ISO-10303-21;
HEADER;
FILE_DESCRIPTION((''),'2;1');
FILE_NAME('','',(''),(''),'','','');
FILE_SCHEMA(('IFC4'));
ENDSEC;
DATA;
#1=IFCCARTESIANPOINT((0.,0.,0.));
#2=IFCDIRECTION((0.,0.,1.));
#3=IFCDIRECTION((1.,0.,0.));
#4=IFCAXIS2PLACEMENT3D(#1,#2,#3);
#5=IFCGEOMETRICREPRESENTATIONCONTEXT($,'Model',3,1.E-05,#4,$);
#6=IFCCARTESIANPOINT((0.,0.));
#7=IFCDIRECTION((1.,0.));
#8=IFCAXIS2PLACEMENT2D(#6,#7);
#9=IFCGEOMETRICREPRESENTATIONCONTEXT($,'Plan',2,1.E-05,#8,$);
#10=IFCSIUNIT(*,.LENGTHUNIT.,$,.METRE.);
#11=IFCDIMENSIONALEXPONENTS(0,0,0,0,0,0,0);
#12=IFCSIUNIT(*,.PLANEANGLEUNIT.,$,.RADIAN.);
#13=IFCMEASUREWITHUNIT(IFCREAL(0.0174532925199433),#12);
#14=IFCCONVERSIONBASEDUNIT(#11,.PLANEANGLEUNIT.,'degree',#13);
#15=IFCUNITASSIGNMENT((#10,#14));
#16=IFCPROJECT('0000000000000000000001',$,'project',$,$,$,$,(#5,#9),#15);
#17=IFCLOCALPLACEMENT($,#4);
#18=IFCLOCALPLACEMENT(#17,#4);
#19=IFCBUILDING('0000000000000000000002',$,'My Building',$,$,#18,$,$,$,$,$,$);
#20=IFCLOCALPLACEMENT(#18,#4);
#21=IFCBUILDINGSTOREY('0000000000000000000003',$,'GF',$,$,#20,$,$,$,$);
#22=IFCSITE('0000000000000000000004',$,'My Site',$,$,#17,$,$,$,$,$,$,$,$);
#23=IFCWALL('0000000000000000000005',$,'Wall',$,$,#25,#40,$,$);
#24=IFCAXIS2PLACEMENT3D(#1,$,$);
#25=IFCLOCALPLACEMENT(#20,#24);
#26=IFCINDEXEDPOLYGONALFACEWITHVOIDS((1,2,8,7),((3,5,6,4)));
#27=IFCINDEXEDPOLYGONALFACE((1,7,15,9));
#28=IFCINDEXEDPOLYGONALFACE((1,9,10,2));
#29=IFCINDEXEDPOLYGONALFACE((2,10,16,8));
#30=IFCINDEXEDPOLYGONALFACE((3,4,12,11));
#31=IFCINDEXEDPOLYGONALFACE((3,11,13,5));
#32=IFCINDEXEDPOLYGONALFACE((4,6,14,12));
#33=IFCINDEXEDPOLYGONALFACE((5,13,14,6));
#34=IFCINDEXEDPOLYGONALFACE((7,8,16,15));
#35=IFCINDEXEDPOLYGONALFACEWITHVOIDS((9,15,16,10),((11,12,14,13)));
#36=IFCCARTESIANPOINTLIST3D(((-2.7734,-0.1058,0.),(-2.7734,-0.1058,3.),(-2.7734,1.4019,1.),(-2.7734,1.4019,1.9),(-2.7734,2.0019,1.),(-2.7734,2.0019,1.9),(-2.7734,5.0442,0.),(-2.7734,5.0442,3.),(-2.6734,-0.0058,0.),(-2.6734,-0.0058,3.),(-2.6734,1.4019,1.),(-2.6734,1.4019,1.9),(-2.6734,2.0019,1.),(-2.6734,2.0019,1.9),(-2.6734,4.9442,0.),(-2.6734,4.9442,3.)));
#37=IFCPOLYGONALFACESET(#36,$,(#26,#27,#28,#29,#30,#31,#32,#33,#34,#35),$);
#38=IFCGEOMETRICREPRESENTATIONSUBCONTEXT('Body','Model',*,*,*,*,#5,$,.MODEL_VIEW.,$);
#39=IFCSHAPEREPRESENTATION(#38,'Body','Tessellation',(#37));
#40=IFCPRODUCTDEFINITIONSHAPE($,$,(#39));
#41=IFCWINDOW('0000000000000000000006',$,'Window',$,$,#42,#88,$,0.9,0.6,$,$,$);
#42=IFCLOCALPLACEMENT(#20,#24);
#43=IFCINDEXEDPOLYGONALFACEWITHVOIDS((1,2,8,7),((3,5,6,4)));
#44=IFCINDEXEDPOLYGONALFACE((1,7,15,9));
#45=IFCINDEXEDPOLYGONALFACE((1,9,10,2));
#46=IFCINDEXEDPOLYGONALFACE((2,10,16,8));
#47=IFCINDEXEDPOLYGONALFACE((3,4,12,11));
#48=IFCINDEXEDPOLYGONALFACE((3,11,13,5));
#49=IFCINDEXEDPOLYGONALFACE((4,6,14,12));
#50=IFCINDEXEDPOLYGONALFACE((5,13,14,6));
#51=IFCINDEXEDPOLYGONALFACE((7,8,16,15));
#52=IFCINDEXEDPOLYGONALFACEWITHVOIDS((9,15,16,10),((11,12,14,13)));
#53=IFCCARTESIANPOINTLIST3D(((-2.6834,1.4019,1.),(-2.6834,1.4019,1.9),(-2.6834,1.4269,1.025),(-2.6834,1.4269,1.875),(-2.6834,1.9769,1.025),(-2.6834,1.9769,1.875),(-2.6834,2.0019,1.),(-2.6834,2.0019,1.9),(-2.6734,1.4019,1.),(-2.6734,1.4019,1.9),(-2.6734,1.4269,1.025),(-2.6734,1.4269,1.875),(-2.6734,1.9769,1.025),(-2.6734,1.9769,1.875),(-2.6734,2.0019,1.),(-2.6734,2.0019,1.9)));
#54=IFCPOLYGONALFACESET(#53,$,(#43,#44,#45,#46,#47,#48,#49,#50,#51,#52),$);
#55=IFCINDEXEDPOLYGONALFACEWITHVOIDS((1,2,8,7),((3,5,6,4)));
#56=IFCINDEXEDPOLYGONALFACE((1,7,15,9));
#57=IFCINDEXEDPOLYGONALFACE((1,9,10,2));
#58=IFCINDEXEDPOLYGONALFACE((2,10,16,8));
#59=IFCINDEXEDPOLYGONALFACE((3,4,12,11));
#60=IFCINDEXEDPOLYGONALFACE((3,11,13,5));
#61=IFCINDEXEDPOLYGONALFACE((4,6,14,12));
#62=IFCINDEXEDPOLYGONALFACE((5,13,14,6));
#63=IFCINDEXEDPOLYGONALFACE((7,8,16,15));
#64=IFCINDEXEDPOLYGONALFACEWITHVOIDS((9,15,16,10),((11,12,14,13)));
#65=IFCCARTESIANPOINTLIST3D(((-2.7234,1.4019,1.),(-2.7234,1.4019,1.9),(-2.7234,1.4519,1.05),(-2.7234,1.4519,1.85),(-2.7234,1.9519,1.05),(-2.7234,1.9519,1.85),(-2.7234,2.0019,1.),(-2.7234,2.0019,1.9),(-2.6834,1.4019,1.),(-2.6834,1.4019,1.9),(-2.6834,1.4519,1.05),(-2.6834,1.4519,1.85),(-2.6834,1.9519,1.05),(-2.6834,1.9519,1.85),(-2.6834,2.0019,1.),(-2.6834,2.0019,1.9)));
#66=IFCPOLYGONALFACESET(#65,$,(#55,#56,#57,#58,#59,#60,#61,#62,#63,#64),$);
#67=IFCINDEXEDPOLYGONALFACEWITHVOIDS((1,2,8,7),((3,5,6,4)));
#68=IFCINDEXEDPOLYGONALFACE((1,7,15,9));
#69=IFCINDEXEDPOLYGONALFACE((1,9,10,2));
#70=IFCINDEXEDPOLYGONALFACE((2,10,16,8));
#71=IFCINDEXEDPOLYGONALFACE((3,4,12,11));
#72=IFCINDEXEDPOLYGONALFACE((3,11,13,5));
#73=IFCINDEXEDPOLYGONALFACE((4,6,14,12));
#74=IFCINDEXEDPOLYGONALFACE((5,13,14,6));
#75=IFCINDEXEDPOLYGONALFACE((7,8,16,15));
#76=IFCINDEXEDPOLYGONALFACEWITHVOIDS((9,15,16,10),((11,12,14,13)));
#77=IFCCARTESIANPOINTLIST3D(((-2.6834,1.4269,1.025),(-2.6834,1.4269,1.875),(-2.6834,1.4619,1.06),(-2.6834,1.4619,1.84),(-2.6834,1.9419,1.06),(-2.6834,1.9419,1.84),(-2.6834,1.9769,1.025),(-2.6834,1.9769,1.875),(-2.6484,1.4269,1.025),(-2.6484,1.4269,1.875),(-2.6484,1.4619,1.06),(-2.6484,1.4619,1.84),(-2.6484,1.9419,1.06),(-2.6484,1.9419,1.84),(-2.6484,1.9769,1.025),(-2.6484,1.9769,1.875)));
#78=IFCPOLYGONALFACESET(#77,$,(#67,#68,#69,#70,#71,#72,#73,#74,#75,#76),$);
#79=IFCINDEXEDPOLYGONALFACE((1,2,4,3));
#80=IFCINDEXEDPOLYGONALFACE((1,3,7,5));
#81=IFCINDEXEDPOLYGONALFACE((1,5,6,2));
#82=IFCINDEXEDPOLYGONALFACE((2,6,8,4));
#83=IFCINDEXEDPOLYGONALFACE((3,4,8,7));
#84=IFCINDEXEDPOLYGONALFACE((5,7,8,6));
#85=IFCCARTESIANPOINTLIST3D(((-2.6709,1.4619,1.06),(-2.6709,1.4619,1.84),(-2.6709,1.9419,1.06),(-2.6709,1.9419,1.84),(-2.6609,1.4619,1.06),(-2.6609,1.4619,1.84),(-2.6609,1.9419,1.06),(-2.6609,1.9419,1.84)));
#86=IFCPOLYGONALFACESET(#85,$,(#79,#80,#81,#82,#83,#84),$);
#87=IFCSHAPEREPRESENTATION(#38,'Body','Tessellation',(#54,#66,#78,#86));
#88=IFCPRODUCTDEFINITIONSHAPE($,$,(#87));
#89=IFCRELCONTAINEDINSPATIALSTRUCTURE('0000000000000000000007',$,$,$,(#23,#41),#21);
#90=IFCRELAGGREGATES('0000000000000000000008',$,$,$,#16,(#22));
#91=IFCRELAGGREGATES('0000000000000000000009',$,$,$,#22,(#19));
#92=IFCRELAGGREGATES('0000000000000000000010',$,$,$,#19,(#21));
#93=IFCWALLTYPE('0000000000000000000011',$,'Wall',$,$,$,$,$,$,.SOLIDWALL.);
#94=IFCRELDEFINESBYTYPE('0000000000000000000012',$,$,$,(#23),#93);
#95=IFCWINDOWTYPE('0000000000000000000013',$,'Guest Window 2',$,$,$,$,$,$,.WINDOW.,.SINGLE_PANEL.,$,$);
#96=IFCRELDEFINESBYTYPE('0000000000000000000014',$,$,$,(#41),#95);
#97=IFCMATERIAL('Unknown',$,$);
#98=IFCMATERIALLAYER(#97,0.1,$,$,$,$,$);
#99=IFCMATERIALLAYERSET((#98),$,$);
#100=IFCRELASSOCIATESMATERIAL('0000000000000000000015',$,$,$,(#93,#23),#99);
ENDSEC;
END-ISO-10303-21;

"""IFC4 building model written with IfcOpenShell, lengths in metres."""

from ifc_helpers import new_model, entity, si_unit, converted_unit, frame, origin_with_axes, origin_2d_with_axis, place, context, subcontext, project, spatial, line, indexed_curve, outline, extrude, shape, source, transform, mapped, material, layer, layer_set, layer_usage, type_object, type_shapes, element, fill, save


model = new_model("IFC4")

# Units and contexts
model_context = context("Model", 3, precision=1e-05, world=origin_with_axes())
plan_context = context("Plan", 2, precision=1e-05, world=origin_2d_with_axis())
body_context_1 = subcontext(model_context, "Body", "Model", "MODEL_VIEW")
body_context_2 = subcontext(plan_context, "Body", "Plan", "PLAN_VIEW")
ifc_project = project(units=[si_unit("LENGTHUNIT", "METRE"), converted_unit("PLANEANGLEUNIT", "degree", entity("IfcReal", 0.0174532925199433), si_unit("PLANEANGLEUNIT", "RADIAN"), dimensions=[0, 0, 0, 0, 0, 0, 0])], contexts=[model_context, plan_context])

# Site, building, storey
site_placement = place(None, origin_with_axes())
site = spatial("IfcSite", under=ifc_project, at=site_placement, Name="My Site")
building_placement = place(site_placement, origin_with_axes())
building = spatial("IfcBuilding", under=site, at=building_placement, Name="My Building")
storey_placement = place(building_placement, origin_with_axes())
storey = spatial("IfcBuildingStorey", under=building, at=storey_placement, Name="GF")

# Shared definitions
ifc_material = material(Name="Unknown")

# Shared definitions
ifc_layer_1 = layer(ifc_material, 0.1)
ifc_layer_set_1 = layer_set([ifc_layer_1])
wall_type = type_object("IfcWallType", Name="Wall", PredefinedType="SOLIDWALL", material=ifc_layer_set_1)

# Wall, opening, window
ifc_layer_usage_1 = layer_usage(ifc_layer_set_1, "AXIS2", "POSITIVE", 0.0)
wall_1_placement = place(storey_placement, frame((-2.7734, 5.0442, 0.0), z_axis=(0.0, 0.0, 1.0), x_axis=(0.0, -1.0, 0.0)))
wall_1 = element("IfcWall", 1, at=wall_1_placement, inside=storey, type_object=wall_type, material=ifc_layer_usage_1, Name="Wall", context=body_context_1, shape_type="SweptSolid", body=[
    extrude(outline(indexed_curve([(0.0, 0.0), (0.1, 0.1), (5.05, 0.1), (5.15, 0.0)], segments=[line(1, 2, 3, 4, 1)])), origin_with_axes(), (0.0, 0.0, 1.0), 3.0),
])
shared_shape_1 = source(origin_with_axes(), body_context_1, "Body", "SweptSolid", [
    extrude(outline(indexed_curve([(0.0, 0.0), (0.6, 0.0), (0.6, 0.9), (0.0, 0.9)], segments=[line(1, 2, 3, 4, 1)])), frame((0.0, -0.6, 0.0), z_axis=(0.0, -1.0, 0.0), x_axis=(1.0, 0.0, 0.0)), (0.0, 0.0, -1.0), 1.2),
])
opening_1_placement = place(wall_1_placement, frame((3.0423, 0.0, 1.0), z_axis=(0.0, 0.0, 1.0), x_axis=(1.0, 0.0, 0.0)))
opening_1 = element("IfcOpeningElement", 2, at=opening_1_placement, cuts=wall_1, PredefinedType="OPENING", context=body_context_1, shape_type="MappedRepresentation", body=[
    mapped(shared_shape_1, transform((0.0, 0.0, 0.0), x_axis=(1.0, 0.0, 0.0), y_axis=(0.0, 1.0, 0.0), z_axis=(0.0, 0.0, 1.0), scale=1.0)),
])
window_type_1 = type_object("IfcWindowType", Name="Guest Window 2", PartitioningType="SINGLE_PANEL", PredefinedType="WINDOW")
shared_shape_2 = source(origin_with_axes(), body_context_1, "Body", "SweptSolid", [
    extrude(outline(indexed_curve([(0.0, 0.0), (0.6, 0.0), (0.6, 0.9), (0.0, 0.9)], segments=[line(1, 2, 3, 4, 1)]), holes=[indexed_curve([(0.025, 0.025), (0.575, 0.025), (0.575, 0.875), (0.025, 0.875)], segments=[line(1, 2, 3, 4, 1)])]), frame((0.0, 0.09, 0.0), z_axis=(0.0, -1.0, 0.0), x_axis=(1.0, 0.0, 0.0)), (0.0, 0.0, -1.0), 0.01),
    extrude(outline(indexed_curve([(0.0, 0.0), (0.6, 0.0), (0.6, 0.9), (0.0, 0.9)], segments=[line(1, 2, 3, 4, 1)]), holes=[indexed_curve([(0.05, 0.05), (0.55, 0.05), (0.55, 0.85), (0.05, 0.85)], segments=[line(1, 2, 3, 4, 1)])]), frame((0.0, 0.05, 0.0), z_axis=(0.0, -1.0, 0.0), x_axis=(1.0, 0.0, 0.0)), (0.0, 0.0, -1.0), 0.04),
    extrude(outline(indexed_curve([(0.0, 0.0), (0.55, 0.0), (0.55, 0.85), (0.0, 0.85)], segments=[line(1, 2, 3, 4, 1)]), holes=[indexed_curve([(0.035, 0.035), (0.515, 0.035), (0.515, 0.815), (0.035, 0.815)], segments=[line(1, 2, 3, 4, 1)])]), frame((0.025, 0.09, 0.025), z_axis=(0.0, -1.0, 0.0), x_axis=(1.0, 0.0, 0.0)), (0.0, 0.0, -1.0), 0.035),
    extrude(outline(indexed_curve([(0.035, 0.035), (0.515, 0.035), (0.515, 0.815), (0.035, 0.815)], segments=[line(1, 2, 3, 4, 1)])), frame((0.025, 0.1025, 0.025), z_axis=(0.0, -1.0, 0.0), x_axis=(1.0, 0.0, 0.0)), (0.0, 0.0, -1.0), 0.01),
])
shared_shape_3 = source(origin_with_axes(), body_context_2, "Body", "Curve2D", [
    entity("IfcIndexedPolyCurve", entity("IfcCartesianPointList2D", [[0.05, 0.05], [0.55, 0.05]])),
    entity("IfcIndexedPolyCurve", entity("IfcCartesianPointList2D", [[0.0, 0.1], [0.025, 0.1], [0.025, 0.09], [0.05, 0.09], [0.05, 0.05], [0.0, 0.05]]), [entity("IfcLineIndex", [1, 2, 3, 4, 5, 6, 1])]),
    entity("IfcIndexedPolyCurve", entity("IfcCartesianPointList2D", [[0.6, 0.1], [0.575, 0.1], [0.575, 0.09], [0.55, 0.09], [0.55, 0.05], [0.6, 0.05]]), [entity("IfcLineIndex", [1, 2, 3, 4, 5, 6, 1])]),
    entity("IfcIndexedPolyCurve", entity("IfcCartesianPointList2D", [[0.025, 0.09], [0.06, 0.09], [0.06, 0.125], [0.025, 0.125]]), [entity("IfcLineIndex", [1, 2, 3, 4, 1])]),
    entity("IfcIndexedPolyCurve", entity("IfcCartesianPointList2D", [[0.575, 0.09], [0.54, 0.09], [0.54, 0.125], [0.575, 0.125]]), [entity("IfcLineIndex", [1, 2, 3, 4, 1])]),
    entity("IfcIndexedPolyCurve", entity("IfcCartesianPointList2D", [[0.06, 0.09], [0.54, 0.09]])),
    entity("IfcIndexedPolyCurve", entity("IfcCartesianPointList2D", [[0.06, 0.125], [0.54, 0.125]])),
    entity("IfcIndexedPolyCurve", entity("IfcCartesianPointList2D", [[0.06, 0.1075], [0.54, 0.1075]])),
])
type_shapes(window_type_1, [shared_shape_2, shared_shape_3])
window_1_placement = place(opening_1_placement, frame((0.0, 0.0, 0.0), z_axis=(0.0, 0.0, 1.0), x_axis=(1.0, 0.0, 0.0)))
window_1 = element("IfcWindow", 3, at=window_1_placement, inside=storey, type_object=window_type_1, Name="Window", OverallHeight=0.9, OverallWidth=0.6, shapes=[
    shape(body_context_1, "Body", "MappedRepresentation", [mapped(shared_shape_2, transform((0.0, 0.0, 0.0), x_axis=(1.0, 0.0, 0.0), y_axis=(0.0, 1.0, 0.0), z_axis=(0.0, 0.0, 1.0), scale=1.0))]),
    shape(body_context_2, "Body", "MappedRepresentation", [mapped(shared_shape_3, transform((0.0, 0.0, 0.0), x_axis=(1.0, 0.0, 0.0), y_axis=(0.0, 1.0, 0.0), z_axis=(0.0, 0.0, 1.0), scale=1.0))]),
])
fill(opening_1, window_1)

save(model, "model.ifc")
